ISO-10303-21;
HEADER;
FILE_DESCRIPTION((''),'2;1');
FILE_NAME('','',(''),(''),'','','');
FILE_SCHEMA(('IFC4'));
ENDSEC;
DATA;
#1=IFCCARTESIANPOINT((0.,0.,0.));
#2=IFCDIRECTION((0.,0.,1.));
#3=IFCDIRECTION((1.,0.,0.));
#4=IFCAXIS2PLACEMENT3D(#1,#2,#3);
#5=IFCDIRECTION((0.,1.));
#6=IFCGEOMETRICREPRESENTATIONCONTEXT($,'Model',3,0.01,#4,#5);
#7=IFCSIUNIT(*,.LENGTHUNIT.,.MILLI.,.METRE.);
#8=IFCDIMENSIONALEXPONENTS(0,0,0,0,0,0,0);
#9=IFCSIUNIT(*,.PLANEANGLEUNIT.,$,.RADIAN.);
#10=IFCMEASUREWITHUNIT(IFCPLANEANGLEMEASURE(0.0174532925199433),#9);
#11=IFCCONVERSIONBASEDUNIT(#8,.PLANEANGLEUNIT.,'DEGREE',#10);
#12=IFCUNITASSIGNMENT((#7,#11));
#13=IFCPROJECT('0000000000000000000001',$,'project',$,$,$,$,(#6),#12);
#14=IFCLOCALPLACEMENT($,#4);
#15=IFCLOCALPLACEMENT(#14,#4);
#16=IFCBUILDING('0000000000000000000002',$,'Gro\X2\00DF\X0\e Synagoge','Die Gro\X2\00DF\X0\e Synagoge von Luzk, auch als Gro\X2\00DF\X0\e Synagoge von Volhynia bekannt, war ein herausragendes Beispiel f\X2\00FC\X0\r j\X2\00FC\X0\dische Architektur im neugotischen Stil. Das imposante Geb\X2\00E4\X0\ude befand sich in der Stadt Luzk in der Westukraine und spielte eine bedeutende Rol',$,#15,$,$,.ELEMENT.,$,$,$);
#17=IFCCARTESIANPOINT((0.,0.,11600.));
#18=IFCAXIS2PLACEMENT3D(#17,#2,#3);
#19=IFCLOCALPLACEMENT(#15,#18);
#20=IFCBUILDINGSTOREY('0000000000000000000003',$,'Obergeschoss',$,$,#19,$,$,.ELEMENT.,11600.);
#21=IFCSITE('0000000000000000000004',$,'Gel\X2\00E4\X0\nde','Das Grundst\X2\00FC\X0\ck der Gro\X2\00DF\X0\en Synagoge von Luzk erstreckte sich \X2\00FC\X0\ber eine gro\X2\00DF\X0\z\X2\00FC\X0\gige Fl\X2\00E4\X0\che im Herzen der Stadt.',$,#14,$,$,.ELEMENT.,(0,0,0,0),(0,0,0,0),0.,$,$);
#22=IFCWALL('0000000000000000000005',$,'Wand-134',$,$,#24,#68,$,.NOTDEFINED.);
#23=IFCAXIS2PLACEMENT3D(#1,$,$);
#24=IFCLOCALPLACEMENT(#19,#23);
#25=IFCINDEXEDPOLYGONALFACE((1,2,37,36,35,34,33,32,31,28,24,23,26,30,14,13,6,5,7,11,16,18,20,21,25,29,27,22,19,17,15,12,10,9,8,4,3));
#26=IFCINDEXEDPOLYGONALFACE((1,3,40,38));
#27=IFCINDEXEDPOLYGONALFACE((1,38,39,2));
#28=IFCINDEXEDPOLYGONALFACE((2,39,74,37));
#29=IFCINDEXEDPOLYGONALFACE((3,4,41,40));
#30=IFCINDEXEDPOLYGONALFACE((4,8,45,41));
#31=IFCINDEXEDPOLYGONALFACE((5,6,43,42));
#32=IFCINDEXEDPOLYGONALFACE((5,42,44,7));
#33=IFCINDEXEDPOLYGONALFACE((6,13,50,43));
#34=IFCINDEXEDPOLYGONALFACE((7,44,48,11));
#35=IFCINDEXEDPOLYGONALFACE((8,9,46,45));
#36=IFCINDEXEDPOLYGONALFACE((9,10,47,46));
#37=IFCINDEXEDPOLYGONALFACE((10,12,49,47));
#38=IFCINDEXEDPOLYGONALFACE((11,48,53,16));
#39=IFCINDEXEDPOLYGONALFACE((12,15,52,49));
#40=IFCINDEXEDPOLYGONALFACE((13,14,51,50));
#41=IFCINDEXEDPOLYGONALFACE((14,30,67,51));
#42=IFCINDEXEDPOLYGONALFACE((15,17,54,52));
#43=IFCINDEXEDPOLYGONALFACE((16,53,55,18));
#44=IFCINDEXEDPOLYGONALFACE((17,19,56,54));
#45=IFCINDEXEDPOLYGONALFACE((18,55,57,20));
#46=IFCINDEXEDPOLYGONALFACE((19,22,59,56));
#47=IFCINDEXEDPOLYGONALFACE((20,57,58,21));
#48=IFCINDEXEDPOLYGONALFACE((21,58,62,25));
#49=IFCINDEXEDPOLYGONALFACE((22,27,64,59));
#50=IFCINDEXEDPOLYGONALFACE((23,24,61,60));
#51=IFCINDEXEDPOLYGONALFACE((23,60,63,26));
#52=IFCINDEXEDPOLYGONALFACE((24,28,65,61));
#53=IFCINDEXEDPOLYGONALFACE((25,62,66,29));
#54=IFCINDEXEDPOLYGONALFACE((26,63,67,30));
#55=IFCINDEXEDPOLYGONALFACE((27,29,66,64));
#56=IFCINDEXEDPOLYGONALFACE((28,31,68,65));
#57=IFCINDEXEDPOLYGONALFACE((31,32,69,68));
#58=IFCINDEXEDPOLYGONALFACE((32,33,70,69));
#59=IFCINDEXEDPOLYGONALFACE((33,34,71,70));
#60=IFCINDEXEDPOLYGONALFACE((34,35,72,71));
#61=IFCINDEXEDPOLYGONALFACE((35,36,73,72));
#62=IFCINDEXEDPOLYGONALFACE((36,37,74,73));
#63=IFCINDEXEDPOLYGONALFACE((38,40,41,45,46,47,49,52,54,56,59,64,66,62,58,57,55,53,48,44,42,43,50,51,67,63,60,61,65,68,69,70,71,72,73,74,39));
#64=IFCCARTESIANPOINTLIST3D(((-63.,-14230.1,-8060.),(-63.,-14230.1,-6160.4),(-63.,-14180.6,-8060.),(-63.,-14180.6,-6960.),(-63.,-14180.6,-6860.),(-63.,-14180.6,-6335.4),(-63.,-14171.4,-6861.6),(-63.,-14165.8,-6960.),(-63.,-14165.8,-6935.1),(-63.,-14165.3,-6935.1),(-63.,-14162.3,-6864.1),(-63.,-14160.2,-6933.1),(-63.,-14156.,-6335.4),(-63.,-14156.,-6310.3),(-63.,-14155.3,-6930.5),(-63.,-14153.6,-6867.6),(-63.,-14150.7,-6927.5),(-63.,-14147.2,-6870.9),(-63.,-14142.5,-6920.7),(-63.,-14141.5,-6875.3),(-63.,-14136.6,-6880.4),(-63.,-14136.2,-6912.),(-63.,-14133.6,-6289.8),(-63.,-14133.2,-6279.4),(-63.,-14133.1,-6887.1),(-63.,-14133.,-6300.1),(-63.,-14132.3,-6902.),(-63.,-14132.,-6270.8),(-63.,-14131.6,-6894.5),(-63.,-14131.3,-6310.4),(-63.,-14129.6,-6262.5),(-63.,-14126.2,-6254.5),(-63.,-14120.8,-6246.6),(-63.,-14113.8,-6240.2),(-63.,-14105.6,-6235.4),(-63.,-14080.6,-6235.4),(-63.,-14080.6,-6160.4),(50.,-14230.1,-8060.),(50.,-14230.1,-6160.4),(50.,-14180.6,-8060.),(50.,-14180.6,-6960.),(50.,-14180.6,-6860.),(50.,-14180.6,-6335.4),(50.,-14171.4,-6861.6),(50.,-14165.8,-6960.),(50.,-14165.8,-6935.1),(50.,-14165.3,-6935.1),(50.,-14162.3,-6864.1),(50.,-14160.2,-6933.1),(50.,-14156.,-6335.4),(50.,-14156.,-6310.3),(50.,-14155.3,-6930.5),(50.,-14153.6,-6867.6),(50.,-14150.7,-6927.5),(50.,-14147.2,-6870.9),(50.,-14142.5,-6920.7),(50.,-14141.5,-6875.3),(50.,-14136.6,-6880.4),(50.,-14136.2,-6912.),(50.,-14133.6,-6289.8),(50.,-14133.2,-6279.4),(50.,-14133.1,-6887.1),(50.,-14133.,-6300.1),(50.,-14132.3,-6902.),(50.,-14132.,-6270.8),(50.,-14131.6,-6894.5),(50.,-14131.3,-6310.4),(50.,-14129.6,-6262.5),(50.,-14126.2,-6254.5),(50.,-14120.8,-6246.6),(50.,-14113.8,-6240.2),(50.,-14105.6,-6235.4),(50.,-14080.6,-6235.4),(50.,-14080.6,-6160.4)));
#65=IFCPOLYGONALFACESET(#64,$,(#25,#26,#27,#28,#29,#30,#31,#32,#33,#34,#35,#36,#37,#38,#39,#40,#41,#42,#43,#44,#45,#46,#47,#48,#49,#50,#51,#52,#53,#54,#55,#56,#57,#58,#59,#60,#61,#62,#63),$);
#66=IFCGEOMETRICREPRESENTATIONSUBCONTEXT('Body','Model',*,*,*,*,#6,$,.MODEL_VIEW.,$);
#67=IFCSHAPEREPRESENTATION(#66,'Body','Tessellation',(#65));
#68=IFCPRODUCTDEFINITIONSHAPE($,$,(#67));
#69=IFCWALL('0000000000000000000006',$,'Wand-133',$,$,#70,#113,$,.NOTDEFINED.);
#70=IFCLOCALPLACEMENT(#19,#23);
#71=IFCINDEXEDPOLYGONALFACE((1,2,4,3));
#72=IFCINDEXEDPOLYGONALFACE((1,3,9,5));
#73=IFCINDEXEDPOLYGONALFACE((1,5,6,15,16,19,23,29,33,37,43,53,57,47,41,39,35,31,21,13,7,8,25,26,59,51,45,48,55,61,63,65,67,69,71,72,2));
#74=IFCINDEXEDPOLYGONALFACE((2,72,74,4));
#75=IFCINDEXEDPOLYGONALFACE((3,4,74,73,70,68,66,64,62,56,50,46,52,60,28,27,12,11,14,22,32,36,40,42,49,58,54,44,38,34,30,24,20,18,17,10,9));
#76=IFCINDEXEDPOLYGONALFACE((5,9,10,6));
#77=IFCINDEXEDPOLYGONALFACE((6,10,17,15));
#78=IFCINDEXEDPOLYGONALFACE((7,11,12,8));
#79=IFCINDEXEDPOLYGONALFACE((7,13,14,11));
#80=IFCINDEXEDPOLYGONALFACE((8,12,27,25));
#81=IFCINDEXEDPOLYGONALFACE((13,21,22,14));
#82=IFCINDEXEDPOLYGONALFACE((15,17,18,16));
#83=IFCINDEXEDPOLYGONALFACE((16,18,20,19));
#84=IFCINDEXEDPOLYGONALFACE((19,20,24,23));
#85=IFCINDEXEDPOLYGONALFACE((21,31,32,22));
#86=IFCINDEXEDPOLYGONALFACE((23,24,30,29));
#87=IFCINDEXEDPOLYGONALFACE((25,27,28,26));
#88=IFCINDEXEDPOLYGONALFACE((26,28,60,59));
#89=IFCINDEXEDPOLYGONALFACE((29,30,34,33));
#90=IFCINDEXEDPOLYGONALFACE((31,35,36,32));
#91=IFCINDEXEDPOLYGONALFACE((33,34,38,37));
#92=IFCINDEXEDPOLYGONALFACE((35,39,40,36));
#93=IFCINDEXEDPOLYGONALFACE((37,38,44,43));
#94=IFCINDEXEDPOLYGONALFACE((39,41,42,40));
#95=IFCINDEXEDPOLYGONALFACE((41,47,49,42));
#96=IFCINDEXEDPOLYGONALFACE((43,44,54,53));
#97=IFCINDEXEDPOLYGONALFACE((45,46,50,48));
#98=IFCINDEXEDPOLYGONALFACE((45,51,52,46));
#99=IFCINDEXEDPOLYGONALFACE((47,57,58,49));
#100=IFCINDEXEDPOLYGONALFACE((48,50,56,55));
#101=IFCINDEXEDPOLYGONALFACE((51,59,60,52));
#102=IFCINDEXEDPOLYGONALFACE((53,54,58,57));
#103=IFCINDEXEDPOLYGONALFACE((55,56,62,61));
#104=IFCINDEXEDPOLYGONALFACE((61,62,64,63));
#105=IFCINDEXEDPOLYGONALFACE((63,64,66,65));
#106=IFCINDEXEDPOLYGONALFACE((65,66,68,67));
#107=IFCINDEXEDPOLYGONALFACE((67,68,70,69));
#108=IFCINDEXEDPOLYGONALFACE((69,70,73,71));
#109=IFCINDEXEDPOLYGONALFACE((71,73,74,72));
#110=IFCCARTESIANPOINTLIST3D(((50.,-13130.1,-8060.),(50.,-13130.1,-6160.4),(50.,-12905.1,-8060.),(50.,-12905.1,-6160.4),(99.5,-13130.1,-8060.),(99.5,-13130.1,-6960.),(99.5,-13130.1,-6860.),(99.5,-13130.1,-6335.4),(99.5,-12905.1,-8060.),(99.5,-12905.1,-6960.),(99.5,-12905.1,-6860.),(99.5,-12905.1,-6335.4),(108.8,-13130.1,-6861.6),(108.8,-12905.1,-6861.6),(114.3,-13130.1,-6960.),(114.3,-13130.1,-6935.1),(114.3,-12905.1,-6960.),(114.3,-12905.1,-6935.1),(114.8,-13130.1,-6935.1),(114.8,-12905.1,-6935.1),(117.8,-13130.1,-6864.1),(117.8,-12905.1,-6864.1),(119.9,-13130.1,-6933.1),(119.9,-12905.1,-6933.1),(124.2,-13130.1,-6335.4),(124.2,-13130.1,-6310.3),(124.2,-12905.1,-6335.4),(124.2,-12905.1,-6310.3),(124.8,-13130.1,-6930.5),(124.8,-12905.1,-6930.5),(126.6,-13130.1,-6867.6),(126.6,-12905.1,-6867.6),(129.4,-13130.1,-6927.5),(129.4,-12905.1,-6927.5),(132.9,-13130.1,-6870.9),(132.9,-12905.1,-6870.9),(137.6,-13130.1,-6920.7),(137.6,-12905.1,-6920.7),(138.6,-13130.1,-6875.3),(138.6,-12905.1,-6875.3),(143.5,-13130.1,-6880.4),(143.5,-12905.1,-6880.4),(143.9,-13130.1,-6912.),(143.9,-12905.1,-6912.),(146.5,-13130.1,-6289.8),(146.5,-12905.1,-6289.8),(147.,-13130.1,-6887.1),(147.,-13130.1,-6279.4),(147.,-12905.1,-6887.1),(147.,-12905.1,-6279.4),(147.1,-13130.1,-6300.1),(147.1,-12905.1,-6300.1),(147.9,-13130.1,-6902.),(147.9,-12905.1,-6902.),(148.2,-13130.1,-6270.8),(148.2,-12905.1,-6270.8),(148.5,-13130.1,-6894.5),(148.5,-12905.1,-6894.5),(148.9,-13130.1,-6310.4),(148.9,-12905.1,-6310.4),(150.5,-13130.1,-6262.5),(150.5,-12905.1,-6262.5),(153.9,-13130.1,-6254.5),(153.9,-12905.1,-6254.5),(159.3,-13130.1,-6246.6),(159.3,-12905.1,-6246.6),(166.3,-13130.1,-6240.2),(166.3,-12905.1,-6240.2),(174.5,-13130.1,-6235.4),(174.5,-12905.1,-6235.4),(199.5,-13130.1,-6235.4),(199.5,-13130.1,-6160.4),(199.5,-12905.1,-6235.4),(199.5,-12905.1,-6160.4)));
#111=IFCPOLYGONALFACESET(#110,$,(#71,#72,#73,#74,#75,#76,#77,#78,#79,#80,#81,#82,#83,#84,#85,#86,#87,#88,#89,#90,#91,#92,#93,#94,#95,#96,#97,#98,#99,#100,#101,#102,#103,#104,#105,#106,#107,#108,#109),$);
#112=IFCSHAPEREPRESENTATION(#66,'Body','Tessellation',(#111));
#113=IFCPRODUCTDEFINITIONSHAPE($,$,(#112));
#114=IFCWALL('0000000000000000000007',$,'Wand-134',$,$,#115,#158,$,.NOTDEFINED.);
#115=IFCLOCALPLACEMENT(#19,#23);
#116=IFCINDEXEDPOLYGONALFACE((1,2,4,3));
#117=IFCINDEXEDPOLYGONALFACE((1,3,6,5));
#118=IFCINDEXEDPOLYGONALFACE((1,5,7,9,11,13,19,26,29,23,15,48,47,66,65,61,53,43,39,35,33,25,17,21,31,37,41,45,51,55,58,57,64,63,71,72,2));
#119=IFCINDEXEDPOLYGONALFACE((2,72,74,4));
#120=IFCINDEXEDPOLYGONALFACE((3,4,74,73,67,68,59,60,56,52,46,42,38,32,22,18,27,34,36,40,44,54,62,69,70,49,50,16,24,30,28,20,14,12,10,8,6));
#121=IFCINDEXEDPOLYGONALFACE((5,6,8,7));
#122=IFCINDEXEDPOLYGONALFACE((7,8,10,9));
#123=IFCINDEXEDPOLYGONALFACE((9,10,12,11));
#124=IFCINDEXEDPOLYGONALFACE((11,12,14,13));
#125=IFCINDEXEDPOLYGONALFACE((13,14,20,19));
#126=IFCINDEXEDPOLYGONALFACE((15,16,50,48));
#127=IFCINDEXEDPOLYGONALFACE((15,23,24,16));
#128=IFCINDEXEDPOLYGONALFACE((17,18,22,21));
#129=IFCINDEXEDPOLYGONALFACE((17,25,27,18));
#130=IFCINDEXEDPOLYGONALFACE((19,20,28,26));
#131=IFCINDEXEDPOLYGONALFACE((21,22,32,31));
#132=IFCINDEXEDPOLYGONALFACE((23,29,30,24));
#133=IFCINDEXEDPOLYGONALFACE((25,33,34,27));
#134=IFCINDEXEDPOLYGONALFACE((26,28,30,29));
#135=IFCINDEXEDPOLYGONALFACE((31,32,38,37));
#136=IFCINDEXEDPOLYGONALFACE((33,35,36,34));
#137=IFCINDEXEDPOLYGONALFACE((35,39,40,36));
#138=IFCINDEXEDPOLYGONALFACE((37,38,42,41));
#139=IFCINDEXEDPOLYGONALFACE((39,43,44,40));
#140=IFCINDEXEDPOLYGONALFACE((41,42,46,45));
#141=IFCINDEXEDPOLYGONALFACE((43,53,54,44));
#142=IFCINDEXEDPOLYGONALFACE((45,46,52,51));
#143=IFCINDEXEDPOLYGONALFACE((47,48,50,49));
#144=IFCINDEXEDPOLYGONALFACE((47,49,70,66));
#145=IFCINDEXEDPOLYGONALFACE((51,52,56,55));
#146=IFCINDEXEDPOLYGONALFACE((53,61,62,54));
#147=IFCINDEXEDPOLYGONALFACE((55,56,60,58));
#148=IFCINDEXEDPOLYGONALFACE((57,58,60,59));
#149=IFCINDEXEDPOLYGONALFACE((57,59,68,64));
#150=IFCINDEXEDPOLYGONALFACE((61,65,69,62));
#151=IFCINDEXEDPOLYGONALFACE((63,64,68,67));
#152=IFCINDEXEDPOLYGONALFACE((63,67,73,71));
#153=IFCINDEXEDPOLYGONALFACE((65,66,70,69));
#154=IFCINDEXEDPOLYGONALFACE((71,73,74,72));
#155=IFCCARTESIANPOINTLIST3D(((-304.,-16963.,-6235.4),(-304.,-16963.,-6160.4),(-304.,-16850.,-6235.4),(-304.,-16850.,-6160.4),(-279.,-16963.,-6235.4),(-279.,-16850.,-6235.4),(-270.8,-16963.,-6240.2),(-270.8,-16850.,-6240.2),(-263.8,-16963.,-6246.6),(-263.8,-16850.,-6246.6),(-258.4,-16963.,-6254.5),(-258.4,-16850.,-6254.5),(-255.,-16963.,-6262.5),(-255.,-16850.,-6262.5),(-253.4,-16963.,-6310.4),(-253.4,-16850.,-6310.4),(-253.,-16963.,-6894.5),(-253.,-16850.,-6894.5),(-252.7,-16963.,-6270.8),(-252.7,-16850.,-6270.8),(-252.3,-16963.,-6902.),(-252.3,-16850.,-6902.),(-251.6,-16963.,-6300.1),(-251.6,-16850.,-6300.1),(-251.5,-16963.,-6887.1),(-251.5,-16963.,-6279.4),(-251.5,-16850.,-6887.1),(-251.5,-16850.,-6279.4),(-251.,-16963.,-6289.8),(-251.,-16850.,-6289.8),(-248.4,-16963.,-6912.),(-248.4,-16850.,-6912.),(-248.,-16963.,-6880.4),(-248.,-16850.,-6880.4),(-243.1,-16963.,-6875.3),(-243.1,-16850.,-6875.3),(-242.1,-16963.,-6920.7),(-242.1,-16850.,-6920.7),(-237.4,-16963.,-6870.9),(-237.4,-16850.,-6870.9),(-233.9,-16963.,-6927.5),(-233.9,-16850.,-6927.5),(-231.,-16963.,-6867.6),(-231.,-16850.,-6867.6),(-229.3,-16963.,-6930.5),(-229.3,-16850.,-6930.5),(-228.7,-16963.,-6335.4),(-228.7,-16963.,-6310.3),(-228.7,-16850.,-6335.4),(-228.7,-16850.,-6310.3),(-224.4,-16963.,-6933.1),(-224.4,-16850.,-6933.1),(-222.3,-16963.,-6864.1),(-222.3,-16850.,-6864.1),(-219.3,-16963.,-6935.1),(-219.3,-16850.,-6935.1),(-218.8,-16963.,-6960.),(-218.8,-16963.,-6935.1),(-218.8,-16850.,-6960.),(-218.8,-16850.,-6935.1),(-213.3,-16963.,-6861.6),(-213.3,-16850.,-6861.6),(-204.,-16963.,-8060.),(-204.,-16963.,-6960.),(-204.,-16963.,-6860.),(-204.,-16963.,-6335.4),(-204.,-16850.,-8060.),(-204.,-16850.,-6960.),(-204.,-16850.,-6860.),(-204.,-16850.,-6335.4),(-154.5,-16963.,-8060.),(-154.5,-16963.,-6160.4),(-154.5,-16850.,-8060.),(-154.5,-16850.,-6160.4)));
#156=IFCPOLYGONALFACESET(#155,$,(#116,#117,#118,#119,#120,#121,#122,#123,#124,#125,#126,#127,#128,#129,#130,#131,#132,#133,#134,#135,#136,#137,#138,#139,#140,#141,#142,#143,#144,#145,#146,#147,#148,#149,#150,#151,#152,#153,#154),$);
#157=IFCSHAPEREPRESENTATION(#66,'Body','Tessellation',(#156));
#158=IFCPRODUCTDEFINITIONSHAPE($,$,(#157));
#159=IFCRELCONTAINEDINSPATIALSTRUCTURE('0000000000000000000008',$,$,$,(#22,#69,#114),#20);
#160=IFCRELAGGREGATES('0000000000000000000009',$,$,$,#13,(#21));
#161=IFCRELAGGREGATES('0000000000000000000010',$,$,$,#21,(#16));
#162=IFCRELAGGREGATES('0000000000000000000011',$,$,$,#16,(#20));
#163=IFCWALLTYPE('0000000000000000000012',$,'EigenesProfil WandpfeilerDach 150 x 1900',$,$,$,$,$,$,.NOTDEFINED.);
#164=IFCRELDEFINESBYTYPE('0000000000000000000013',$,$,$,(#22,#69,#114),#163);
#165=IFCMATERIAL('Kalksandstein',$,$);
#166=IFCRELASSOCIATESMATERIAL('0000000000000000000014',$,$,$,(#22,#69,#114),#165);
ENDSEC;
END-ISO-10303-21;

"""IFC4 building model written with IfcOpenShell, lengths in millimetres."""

from ifc_helpers import new_model, entity, si_unit, converted_unit, direction, frame, origin_with_axes, place, context, subcontext, project, spatial, line, arc, indexed_curve, outline, extrude, material, material_profile, profile_set, type_object, element, save


model = new_model("IFC4")

# Units and contexts
model_context = context("Model", 3, precision=0.01, world=origin_with_axes(), true_north=direction((0.0, 1.0)))
body_context = subcontext(model_context, "Body", "Model", "MODEL_VIEW")
ifc_project = project(units=[si_unit("LENGTHUNIT", "METRE", prefix="MILLI"), converted_unit("PLANEANGLEUNIT", "DEGREE", entity("IfcPlaneAngleMeasure", 0.0174532925199433), si_unit("PLANEANGLEUNIT", "RADIAN"), dimensions=[0, 0, 0, 0, 0, 0, 0])], contexts=[model_context])

# Site, building, storey
site_placement = place(None, origin_with_axes())
site = spatial("IfcSite", under=ifc_project, at=site_placement, Name="Gelände", Description="Das Grundstück der Großen Synagoge von Luzk erstreckte sich über eine großzügige Fläche im Herzen der Stadt.", CompositionType="ELEMENT", RefLatitude=(0, 0, 0, 0), RefLongitude=(0, 0, 0, 0), RefElevation=0.0)
building_placement = place(site_placement, origin_with_axes())
building = spatial("IfcBuilding", under=site, at=building_placement, Name="Große Synagoge", Description="Die Große Synagoge von Luzk, auch als Große Synagoge von Volhynia bekannt, war ein herausragendes Beispiel für jüdische Architektur im neugotischen Stil. Das imposante Gebäude befand sich in der Stadt Luzk in der Westukraine und spielte eine bedeutende Rol", CompositionType="ELEMENT")
storey_placement = place(building_placement, frame((0.0, 0.0, 11600.0), z_axis=(0.0, 0.0, 1.0), x_axis=(1.0, 0.0, 0.0)))
storey = spatial("IfcBuildingStorey", under=building, at=storey_placement, Name="Obergeschoss", CompositionType="ELEMENT", Elevation=11600.0)

# Walls
ifc_material_1 = material(Name="Kalksandstein")
ifc_material_profile = material_profile(ifc_material_1, outline(indexed_curve([(74.2, 1749.6), (98.9, 1749.6), (96.7, 1765.0), (97.0, 1780.5), (99.2, 1793.4), (103.9, 1805.5), (112.6, 1816.7), (124.5, 1824.6), (149.5, 1824.6), (149.5, 1899.6), (0.0, 1899.6), (0.0, 0.0), (49.5, 0.0), (49.5, 1100.0), (64.3, 1100.0), (64.3, 1124.9), (64.8, 1124.9), (72.4, 1128.1), (79.4, 1132.4), (91.1, 1143.4), (97.9, 1157.9), (98.0, 1169.2), (93.5, 1179.5), (85.8, 1187.0), (76.6, 1192.3), (63.3, 1197.2), (49.5, 1200.0), (49.5, 1724.6), (74.2, 1724.6)], segments=[line(1, 2), arc(2, 3, 4), arc(4, 5, 6), arc(6, 7, 8), line(8, 9, 10, 11, 12, 13, 14, 15, 16, 17), arc(17, 18, 19), arc(19, 20, 21), arc(21, 22, 23), arc(23, 24, 25), arc(25, 26, 27), line(27, 28, 29, 1)])), Name="Kalksandstein")
ifc_profile_set = profile_set([ifc_material_profile], Name="EigenesProfil WandpfeilerDach")
wall_type_1 = type_object("IfcWallType", Name="EigenesProfil WandpfeilerDach 150 x 1900", PredefinedType="NOTDEFINED")
wall_1_placement = place(storey_placement, frame((50.0, -14230.1, -8060.0), z_axis=(0.0, 0.0, 1.0), x_axis=(-1.0, 0.0, 0.0)))
element("IfcWall", 1, at=wall_1_placement, inside=storey, type_object=wall_type_1, material=ifc_profile_set, Name="Wand-134", PredefinedType="NOTDEFINED", context=body_context, shape_type="SweptSolid", body=[
    extrude(outline(indexed_curve([(74.2, 1749.6), (98.9, 1749.6), (96.7, 1765.0), (97.0, 1780.5), (99.2, 1793.4), (103.9, 1805.5), (112.6, 1816.7), (124.5, 1824.6), (149.5, 1824.6), (149.5, 1899.6), (0.0, 1899.6), (0.0, 0.0), (49.5, 0.0), (49.5, 1100.0), (64.3, 1100.0), (64.3, 1124.9), (64.8, 1124.9), (72.4, 1128.1), (79.4, 1132.4), (91.1, 1143.4), (97.9, 1157.9), (98.0, 1169.2), (93.5, 1179.5), (85.8, 1187.0), (76.6, 1192.3), (63.3, 1197.2), (49.5, 1200.0), (49.5, 1724.6), (74.2, 1724.6)], segments=[line(1, 2), arc(2, 3, 4), arc(4, 5, 6), arc(6, 7, 8), line(8, 9, 10, 11, 12, 13, 14, 15, 16, 17), arc(17, 18, 19), arc(19, 20, 21), arc(21, 22, 23), arc(23, 24, 25), arc(25, 26, 27), line(27, 28, 29, 1)])), frame((0.0, 0.0, 0.0), z_axis=(-1.0, 0.0, 0.0), x_axis=(0.0, -1.0, 0.0)), (0.0, 0.0, -1.0), 113.0),
])
wall_2_placement = place(storey_placement, frame((50.0, -12905.1, -8060.0), z_axis=(0.0, 0.0, 1.0), x_axis=(0.0, -1.0, 0.0)))
element("IfcWall", 2, at=wall_2_placement, inside=storey, type_object=wall_type_1, material=ifc_profile_set, Name="Wand-133", PredefinedType="NOTDEFINED", context=body_context, shape_type="SweptSolid", body=[
    extrude(outline(indexed_curve([(74.2, 1749.6), (98.9, 1749.6), (96.7, 1765.0), (97.0, 1780.5), (99.2, 1793.4), (103.9, 1805.5), (112.6, 1816.7), (124.5, 1824.6), (149.5, 1824.6), (149.5, 1899.6), (0.0, 1899.6), (0.0, 0.0), (49.5, 0.0), (49.5, 1100.0), (64.3, 1100.0), (64.3, 1124.9), (64.8, 1124.9), (72.4, 1128.1), (79.4, 1132.4), (91.1, 1143.4), (97.9, 1157.9), (98.0, 1169.2), (93.5, 1179.5), (85.8, 1187.0), (76.6, 1192.3), (63.3, 1197.2), (49.5, 1200.0), (49.5, 1724.6), (74.2, 1724.6)], segments=[line(1, 2), arc(2, 3, 4), arc(4, 5, 6), arc(6, 7, 8), line(8, 9, 10, 11, 12, 13, 14, 15, 16, 17), arc(17, 18, 19), arc(19, 20, 21), arc(21, 22, 23), arc(23, 24, 25), arc(25, 26, 27), line(27, 28, 29, 1)])), frame((0.0, 0.0, 0.0), z_axis=(1.0, 0.0, 0.0), x_axis=(0.0, 1.0, 0.0)), (0.0, 0.0, 1.0), 225.0),
])
wall_3_placement = place(storey_placement, frame((-154.5, -16850.0, -8060.0), z_axis=(0.0, 0.0, 1.0), x_axis=(0.0, -1.0, 0.0)))
element("IfcWall", 3, at=wall_3_placement, inside=storey, type_object=wall_type_1, material=ifc_profile_set, Name="Wand-134", PredefinedType="NOTDEFINED", context=body_context, shape_type="SweptSolid", body=[
    extrude(outline(indexed_curve([(74.2, 1749.6), (98.9, 1749.6), (96.7, 1765.0), (97.0, 1780.5), (99.2, 1793.4), (103.9, 1805.5), (112.6, 1816.7), (124.5, 1824.6), (149.5, 1824.6), (149.5, 1899.6), (0.0, 1899.6), (0.0, 0.0), (49.5, 0.0), (49.5, 1100.0), (64.3, 1100.0), (64.3, 1124.9), (64.8, 1124.9), (72.4, 1128.1), (79.4, 1132.4), (91.1, 1143.4), (97.9, 1157.9), (98.0, 1169.2), (93.5, 1179.5), (85.8, 1187.0), (76.6, 1192.3), (63.3, 1197.2), (49.5, 1200.0), (49.5, 1724.6), (74.2, 1724.6)], segments=[line(1, 2), arc(2, 3, 4), arc(4, 5, 6), arc(6, 7, 8), line(8, 9, 10, 11, 12, 13, 14, 15, 16, 17), arc(17, 18, 19), arc(19, 20, 21), arc(21, 22, 23), arc(23, 24, 25), arc(25, 26, 27), line(27, 28, 29, 1)])), frame((0.0, 0.0, 0.0), z_axis=(-1.0, 0.0, 0.0), x_axis=(0.0, -1.0, 0.0)), (0.0, 0.0, -1.0), 113.0),
])

save(model, "model.ifc")
